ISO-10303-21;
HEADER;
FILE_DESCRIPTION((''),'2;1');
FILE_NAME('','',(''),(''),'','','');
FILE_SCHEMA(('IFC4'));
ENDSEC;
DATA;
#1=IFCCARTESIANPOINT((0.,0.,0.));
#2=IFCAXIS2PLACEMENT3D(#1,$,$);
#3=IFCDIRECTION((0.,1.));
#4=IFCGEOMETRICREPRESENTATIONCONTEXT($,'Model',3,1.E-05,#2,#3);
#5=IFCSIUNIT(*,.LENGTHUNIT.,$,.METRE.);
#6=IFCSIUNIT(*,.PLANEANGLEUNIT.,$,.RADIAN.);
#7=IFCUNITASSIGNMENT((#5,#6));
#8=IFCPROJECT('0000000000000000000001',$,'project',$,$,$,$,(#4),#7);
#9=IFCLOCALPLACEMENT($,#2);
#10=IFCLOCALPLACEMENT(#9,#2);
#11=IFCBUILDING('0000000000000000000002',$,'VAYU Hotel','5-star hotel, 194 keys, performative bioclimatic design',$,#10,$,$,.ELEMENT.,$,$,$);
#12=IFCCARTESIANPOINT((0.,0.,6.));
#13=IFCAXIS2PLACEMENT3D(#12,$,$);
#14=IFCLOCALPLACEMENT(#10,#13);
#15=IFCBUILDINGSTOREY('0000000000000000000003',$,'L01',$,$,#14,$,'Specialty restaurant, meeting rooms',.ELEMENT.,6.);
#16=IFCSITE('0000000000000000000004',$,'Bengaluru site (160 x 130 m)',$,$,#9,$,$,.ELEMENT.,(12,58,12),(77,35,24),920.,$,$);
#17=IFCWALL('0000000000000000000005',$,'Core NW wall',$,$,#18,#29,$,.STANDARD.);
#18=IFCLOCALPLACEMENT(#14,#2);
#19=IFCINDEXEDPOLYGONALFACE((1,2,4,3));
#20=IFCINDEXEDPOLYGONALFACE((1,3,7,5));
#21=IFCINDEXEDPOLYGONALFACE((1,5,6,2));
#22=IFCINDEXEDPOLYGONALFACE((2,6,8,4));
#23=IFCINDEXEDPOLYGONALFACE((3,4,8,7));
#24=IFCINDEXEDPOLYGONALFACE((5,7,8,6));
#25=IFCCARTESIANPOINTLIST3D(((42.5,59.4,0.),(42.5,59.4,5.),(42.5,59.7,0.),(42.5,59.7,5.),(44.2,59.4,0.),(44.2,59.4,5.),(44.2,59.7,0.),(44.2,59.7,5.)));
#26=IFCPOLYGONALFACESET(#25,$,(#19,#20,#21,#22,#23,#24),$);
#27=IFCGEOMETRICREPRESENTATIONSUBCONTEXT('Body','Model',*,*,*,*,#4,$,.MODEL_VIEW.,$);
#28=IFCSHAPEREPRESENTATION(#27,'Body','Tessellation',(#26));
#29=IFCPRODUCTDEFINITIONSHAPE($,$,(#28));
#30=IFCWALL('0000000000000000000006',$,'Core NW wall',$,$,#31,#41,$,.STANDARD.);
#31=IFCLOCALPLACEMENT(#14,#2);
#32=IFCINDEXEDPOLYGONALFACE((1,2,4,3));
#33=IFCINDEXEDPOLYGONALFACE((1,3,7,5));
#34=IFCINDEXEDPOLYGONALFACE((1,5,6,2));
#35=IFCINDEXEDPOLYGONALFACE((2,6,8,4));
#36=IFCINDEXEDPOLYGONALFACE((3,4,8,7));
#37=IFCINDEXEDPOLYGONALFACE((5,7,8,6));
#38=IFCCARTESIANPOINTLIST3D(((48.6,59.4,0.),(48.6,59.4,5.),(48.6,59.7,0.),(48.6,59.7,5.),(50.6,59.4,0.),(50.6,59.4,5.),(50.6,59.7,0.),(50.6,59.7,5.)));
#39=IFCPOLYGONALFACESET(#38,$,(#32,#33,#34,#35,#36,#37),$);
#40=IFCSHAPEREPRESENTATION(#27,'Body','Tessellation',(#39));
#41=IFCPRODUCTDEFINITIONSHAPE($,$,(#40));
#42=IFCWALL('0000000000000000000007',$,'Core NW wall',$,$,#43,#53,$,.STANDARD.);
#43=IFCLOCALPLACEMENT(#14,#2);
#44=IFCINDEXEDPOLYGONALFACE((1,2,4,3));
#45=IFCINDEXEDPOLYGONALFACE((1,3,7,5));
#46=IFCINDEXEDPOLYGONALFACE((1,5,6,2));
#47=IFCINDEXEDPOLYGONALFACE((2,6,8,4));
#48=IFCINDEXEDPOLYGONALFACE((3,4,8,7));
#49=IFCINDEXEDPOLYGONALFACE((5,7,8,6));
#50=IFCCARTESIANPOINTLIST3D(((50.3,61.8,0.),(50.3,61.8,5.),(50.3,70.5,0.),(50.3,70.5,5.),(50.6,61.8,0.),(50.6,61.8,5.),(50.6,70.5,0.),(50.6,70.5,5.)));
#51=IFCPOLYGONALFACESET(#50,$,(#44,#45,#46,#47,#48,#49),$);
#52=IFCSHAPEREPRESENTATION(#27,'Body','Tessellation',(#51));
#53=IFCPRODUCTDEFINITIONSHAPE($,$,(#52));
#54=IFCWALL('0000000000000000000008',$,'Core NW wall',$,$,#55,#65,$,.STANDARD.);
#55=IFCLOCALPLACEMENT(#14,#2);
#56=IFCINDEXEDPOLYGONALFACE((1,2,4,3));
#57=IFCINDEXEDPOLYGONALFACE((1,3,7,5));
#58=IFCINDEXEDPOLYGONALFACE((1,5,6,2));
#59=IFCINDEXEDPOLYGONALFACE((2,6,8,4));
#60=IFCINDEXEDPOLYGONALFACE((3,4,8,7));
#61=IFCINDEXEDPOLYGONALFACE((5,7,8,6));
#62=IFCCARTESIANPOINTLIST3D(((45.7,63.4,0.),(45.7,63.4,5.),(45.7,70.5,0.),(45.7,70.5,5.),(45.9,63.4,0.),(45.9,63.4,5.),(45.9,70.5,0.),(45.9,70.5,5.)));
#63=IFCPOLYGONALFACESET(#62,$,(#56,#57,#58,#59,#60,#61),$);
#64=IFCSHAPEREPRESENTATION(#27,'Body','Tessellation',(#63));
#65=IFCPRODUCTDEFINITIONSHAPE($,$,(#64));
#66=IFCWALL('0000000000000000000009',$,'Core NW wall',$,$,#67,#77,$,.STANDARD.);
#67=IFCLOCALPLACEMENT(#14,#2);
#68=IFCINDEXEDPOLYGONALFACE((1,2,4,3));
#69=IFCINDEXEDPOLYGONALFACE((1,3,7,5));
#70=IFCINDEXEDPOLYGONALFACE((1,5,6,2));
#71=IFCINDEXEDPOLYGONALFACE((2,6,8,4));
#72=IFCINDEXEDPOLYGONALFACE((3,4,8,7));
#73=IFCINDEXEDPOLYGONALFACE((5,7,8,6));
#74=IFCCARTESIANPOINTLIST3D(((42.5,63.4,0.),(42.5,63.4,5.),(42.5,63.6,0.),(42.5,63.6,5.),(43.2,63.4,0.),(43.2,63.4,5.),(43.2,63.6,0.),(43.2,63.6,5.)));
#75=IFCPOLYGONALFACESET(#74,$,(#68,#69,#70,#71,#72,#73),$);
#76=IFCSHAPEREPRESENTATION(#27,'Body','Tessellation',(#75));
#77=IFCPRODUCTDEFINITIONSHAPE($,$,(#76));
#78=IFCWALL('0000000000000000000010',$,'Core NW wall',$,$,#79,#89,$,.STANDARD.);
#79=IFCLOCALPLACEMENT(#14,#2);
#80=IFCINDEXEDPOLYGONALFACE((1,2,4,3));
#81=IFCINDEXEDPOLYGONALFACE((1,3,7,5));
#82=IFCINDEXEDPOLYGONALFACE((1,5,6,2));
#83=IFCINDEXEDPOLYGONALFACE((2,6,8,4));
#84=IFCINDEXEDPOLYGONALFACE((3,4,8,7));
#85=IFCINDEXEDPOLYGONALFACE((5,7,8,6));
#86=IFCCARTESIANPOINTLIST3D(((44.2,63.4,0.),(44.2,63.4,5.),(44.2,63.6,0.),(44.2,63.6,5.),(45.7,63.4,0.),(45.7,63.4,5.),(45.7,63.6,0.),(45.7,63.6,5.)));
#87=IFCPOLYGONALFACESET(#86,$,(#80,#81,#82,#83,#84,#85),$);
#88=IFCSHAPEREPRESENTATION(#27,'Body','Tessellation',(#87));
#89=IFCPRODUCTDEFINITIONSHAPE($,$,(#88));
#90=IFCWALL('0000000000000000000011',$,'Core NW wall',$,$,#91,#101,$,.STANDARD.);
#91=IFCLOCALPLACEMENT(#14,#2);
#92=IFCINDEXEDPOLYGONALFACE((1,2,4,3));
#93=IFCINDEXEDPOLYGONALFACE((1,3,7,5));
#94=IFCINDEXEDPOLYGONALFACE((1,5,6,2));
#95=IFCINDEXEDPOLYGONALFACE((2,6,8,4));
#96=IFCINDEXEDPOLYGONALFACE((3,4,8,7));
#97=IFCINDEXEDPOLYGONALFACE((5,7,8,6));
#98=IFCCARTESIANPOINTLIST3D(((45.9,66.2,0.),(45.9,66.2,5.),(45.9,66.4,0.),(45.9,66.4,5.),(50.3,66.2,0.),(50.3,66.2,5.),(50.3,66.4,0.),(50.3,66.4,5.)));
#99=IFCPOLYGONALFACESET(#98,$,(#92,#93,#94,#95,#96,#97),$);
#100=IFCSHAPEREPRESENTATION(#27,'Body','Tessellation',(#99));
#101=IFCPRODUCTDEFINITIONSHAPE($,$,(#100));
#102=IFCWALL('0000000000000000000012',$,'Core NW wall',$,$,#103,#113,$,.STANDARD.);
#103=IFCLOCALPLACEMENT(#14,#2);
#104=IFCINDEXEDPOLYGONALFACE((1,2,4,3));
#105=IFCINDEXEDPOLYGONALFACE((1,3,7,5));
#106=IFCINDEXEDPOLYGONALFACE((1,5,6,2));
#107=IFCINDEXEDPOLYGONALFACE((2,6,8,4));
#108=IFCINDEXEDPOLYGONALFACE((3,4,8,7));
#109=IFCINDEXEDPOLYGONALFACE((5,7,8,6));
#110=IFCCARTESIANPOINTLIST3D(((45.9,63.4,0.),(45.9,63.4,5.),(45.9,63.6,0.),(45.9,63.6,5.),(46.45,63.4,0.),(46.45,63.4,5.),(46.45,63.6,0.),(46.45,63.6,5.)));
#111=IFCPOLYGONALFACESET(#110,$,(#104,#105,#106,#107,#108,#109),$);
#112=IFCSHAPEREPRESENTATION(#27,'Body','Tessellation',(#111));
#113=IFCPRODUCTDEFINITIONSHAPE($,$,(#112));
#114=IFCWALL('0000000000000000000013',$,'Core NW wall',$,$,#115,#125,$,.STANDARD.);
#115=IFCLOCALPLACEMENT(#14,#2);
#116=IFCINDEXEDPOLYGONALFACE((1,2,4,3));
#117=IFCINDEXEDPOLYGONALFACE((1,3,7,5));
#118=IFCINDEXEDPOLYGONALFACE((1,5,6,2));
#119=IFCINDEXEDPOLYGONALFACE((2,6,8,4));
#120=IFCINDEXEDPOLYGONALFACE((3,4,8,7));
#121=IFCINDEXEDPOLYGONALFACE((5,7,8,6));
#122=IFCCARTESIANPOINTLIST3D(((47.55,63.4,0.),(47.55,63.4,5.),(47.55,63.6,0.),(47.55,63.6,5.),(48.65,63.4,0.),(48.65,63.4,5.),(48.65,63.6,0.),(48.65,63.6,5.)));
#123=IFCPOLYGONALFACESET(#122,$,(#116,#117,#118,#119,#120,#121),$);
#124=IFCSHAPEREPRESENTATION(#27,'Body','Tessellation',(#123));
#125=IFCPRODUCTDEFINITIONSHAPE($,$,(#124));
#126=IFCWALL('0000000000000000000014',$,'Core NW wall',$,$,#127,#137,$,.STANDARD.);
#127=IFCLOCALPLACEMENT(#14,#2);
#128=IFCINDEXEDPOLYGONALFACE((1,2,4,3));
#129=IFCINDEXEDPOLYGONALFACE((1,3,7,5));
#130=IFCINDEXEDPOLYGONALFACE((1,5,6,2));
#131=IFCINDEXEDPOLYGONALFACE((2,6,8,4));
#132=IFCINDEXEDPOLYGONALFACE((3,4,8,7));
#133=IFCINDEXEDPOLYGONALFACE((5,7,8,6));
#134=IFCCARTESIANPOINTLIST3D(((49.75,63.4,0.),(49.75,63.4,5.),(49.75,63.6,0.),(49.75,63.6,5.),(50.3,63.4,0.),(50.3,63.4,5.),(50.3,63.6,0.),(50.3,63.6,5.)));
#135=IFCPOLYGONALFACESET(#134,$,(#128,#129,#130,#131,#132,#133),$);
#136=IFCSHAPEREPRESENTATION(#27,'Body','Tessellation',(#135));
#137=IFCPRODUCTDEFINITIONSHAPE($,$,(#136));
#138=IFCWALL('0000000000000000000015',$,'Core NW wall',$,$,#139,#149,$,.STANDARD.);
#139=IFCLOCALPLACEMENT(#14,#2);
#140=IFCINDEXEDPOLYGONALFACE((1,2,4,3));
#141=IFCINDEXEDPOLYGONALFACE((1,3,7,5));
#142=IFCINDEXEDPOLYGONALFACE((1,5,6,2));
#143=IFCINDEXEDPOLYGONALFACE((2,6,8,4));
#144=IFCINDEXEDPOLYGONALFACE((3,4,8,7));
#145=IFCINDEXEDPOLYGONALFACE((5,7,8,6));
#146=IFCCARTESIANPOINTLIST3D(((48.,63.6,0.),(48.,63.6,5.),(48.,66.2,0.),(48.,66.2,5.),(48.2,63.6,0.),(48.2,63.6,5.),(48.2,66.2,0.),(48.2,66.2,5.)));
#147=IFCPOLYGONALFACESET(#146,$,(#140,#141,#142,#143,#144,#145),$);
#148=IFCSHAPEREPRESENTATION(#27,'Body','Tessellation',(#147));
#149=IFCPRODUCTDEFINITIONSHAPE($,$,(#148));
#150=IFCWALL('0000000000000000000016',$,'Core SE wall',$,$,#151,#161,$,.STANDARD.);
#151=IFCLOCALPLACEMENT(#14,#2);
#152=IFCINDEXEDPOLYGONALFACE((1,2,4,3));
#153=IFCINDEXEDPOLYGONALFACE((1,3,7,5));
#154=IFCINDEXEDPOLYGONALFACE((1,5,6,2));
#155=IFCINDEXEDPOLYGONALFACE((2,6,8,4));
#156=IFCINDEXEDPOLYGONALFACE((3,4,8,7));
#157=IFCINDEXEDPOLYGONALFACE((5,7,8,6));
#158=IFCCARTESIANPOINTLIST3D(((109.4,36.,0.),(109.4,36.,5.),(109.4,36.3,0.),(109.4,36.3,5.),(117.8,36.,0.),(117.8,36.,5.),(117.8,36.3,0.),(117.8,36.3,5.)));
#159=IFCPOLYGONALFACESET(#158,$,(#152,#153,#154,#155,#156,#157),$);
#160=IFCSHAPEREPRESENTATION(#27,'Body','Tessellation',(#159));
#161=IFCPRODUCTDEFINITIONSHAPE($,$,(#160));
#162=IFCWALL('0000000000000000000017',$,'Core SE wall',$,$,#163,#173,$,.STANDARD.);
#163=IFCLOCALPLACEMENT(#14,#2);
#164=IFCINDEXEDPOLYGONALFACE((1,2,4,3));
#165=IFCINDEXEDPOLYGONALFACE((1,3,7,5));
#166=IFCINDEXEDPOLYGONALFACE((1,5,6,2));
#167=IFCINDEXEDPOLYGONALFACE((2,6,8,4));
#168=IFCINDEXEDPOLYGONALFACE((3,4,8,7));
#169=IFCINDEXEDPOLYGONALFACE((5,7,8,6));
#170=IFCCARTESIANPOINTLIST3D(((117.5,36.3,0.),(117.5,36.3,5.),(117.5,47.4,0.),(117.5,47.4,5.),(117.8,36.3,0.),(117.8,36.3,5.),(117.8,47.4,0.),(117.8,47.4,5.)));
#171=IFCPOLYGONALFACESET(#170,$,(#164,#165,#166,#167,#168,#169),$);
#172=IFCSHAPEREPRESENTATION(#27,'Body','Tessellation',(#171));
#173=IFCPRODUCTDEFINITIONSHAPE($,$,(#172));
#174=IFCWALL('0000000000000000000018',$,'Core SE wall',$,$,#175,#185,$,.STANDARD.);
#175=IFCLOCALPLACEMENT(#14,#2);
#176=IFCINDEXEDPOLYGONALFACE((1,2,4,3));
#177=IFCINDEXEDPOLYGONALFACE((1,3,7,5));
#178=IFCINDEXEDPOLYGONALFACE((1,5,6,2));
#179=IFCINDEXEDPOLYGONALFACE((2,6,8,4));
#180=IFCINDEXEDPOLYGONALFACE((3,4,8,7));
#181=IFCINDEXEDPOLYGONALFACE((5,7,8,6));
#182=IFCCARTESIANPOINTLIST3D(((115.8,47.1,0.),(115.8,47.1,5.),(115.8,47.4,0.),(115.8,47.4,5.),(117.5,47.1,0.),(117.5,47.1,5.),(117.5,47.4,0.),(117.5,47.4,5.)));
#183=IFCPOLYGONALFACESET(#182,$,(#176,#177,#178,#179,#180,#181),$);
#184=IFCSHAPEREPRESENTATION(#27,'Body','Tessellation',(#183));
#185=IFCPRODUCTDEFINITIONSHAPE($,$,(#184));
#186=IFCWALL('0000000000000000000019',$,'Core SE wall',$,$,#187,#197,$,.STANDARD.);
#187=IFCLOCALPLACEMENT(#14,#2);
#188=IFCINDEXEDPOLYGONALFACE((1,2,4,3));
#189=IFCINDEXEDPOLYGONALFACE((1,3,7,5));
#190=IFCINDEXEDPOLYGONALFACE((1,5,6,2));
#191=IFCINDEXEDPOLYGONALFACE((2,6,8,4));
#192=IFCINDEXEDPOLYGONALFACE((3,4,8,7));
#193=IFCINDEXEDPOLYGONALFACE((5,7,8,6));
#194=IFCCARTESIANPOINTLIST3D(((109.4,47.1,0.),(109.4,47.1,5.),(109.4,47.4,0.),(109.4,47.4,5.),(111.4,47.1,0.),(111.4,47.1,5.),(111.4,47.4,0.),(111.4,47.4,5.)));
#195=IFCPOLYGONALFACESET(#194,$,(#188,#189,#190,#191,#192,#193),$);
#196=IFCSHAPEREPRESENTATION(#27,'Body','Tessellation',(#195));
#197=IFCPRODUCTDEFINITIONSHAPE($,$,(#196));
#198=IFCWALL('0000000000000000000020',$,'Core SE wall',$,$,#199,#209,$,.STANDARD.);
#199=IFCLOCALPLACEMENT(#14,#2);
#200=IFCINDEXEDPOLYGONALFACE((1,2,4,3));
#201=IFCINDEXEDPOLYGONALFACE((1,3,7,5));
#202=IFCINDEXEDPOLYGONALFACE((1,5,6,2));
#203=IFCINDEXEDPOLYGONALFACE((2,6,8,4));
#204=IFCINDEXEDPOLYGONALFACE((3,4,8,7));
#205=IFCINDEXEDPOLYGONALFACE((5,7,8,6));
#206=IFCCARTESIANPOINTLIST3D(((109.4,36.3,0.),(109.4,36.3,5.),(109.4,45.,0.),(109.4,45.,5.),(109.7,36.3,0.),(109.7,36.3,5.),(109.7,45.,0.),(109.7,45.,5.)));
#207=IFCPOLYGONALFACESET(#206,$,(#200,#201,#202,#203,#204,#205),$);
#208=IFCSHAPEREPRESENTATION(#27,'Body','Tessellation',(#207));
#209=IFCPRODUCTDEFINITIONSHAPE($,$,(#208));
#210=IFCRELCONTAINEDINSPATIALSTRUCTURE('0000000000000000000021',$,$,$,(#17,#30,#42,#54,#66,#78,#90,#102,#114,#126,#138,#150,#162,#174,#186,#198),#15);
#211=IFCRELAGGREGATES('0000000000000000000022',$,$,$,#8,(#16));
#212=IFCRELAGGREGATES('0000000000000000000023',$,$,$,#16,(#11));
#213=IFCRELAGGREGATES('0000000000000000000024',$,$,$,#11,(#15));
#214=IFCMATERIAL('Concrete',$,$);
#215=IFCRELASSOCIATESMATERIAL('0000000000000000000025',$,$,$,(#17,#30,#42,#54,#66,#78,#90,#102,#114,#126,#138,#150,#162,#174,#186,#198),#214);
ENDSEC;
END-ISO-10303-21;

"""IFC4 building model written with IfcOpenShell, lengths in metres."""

from ifc_helpers import new_model, si_unit, direction, frame, origin, place, context, subcontext, project, spatial, polyline, outline, extrude, material, element, save


model = new_model("IFC4")

# Units and contexts
model_context = context("Model", 3, precision=1e-05, world=origin(), true_north=direction((0.0, 1.0)))
body_context = subcontext(model_context, "Body", "Model", "MODEL_VIEW")
ifc_project = project(units=[si_unit("LENGTHUNIT", "METRE"), si_unit("PLANEANGLEUNIT", "RADIAN")], contexts=[model_context])

# Site, building, storey
site_placement = place(None, origin())
site = spatial("IfcSite", under=ifc_project, at=site_placement, Name="Bengaluru site (160 x 130 m)", CompositionType="ELEMENT", RefLatitude=(12, 58, 12), RefLongitude=(77, 35, 24), RefElevation=920.0)
building_placement = place(site_placement, origin())
building = spatial("IfcBuilding", under=site, at=building_placement, Name="VAYU Hotel", Description="5-star hotel, 194 keys, performative bioclimatic design", CompositionType="ELEMENT")
storey_placement = place(building_placement, frame((0.0, 0.0, 6.0)))
storey = spatial("IfcBuildingStorey", under=building, at=storey_placement, Name="L01", LongName="Specialty restaurant, meeting rooms", CompositionType="ELEMENT", Elevation=6.0)

# Walls
ifc_material = material(Name="Concrete")
wall_1_placement = place(storey_placement, origin())
element("IfcWall", 1, at=wall_1_placement, inside=storey, material=ifc_material, Name="Core NW wall", PredefinedType="STANDARD", context=body_context, shape_type="SweptSolid", body=[
    extrude(outline(polyline([(42.5, 59.7), (44.2, 59.7), (44.2, 59.4), (42.5, 59.4), (42.5, 59.7)])), origin(), (0.0, 0.0, 1.0), 5.0),
])
wall_2_placement = place(storey_placement, origin())
element("IfcWall", 2, at=wall_2_placement, inside=storey, material=ifc_material, Name="Core NW wall", PredefinedType="STANDARD", context=body_context, shape_type="SweptSolid", body=[
    extrude(outline(polyline([(48.6, 59.7), (50.6, 59.7), (50.6, 59.4), (48.6, 59.4), (48.6, 59.7)])), origin(), (0.0, 0.0, 1.0), 5.0),
])
wall_3_placement = place(storey_placement, origin())
element("IfcWall", 3, at=wall_3_placement, inside=storey, material=ifc_material, Name="Core NW wall", PredefinedType="STANDARD", context=body_context, shape_type="SweptSolid", body=[
    extrude(outline(polyline([(50.3, 61.8), (50.3, 70.5), (50.6, 70.5), (50.6, 61.8), (50.3, 61.8)])), origin(), (0.0, 0.0, 1.0), 5.0),
])
wall_4_placement = place(storey_placement, origin())
element("IfcWall", 4, at=wall_4_placement, inside=storey, material=ifc_material, Name="Core NW wall", PredefinedType="STANDARD", context=body_context, shape_type="SweptSolid", body=[
    extrude(outline(polyline([(45.7, 63.4), (45.7, 70.5), (45.9, 70.5), (45.9, 63.4), (45.7, 63.4)])), origin(), (0.0, 0.0, 1.0), 5.0),
])
wall_5_placement = place(storey_placement, origin())
element("IfcWall", 5, at=wall_5_placement, inside=storey, material=ifc_material, Name="Core NW wall", PredefinedType="STANDARD", context=body_context, shape_type="SweptSolid", body=[
    extrude(outline(polyline([(42.5, 63.6), (43.2, 63.6), (43.2, 63.4), (42.5, 63.4), (42.5, 63.6)])), origin(), (0.0, 0.0, 1.0), 5.0),
])
wall_6_placement = place(storey_placement, origin())
element("IfcWall", 6, at=wall_6_placement, inside=storey, material=ifc_material, Name="Core NW wall", PredefinedType="STANDARD", context=body_context, shape_type="SweptSolid", body=[
    extrude(outline(polyline([(44.2, 63.6), (45.7, 63.6), (45.7, 63.4), (44.2, 63.4), (44.2, 63.6)])), origin(), (0.0, 0.0, 1.0), 5.0),
])
wall_7_placement = place(storey_placement, origin())
element("IfcWall", 7, at=wall_7_placement, inside=storey, material=ifc_material, Name="Core NW wall", PredefinedType="STANDARD", context=body_context, shape_type="SweptSolid", body=[
    extrude(outline(polyline([(45.9, 66.4), (50.3, 66.4), (50.3, 66.2), (45.9, 66.2), (45.9, 66.4)])), origin(), (0.0, 0.0, 1.0), 5.0),
])
wall_8_placement = place(storey_placement, origin())
element("IfcWall", 8, at=wall_8_placement, inside=storey, material=ifc_material, Name="Core NW wall", PredefinedType="STANDARD", context=body_context, shape_type="SweptSolid", body=[
    extrude(outline(polyline([(45.9, 63.6), (46.45, 63.6), (46.45, 63.4), (45.9, 63.4), (45.9, 63.6)])), origin(), (0.0, 0.0, 1.0), 5.0),
])
wall_9_placement = place(storey_placement, origin())
element("IfcWall", 9, at=wall_9_placement, inside=storey, material=ifc_material, Name="Core NW wall", PredefinedType="STANDARD", context=body_context, shape_type="SweptSolid", body=[
    extrude(outline(polyline([(47.55, 63.6), (48.65, 63.6), (48.65, 63.4), (47.55, 63.4), (47.55, 63.6)])), origin(), (0.0, 0.0, 1.0), 5.0),
])
wall_10_placement = place(storey_placement, origin())
element("IfcWall", 10, at=wall_10_placement, inside=storey, material=ifc_material, Name="Core NW wall", PredefinedType="STANDARD", context=body_context, shape_type="SweptSolid", body=[
    extrude(outline(polyline([(49.75, 63.6), (50.3, 63.6), (50.3, 63.4), (49.75, 63.4), (49.75, 63.6)])), origin(), (0.0, 0.0, 1.0), 5.0),
])
wall_11_placement = place(storey_placement, origin())
element("IfcWall", 11, at=wall_11_placement, inside=storey, material=ifc_material, Name="Core NW wall", PredefinedType="STANDARD", context=body_context, shape_type="SweptSolid", body=[
    extrude(outline(polyline([(48.0, 63.6), (48.0, 66.2), (48.2, 66.2), (48.2, 63.6), (48.0, 63.6)])), origin(), (0.0, 0.0, 1.0), 5.0),
])
wall_12_placement = place(storey_placement, origin())
element("IfcWall", 12, at=wall_12_placement, inside=storey, material=ifc_material, Name="Core SE wall", PredefinedType="STANDARD", context=body_context, shape_type="SweptSolid", body=[
    extrude(outline(polyline([(109.4, 36.3), (117.8, 36.3), (117.8, 36.0), (109.4, 36.0), (109.4, 36.3)])), origin(), (0.0, 0.0, 1.0), 5.0),
])
wall_13_placement = place(storey_placement, origin())
element("IfcWall", 13, at=wall_13_placement, inside=storey, material=ifc_material, Name="Core SE wall", PredefinedType="STANDARD", context=body_context, shape_type="SweptSolid", body=[
    extrude(outline(polyline([(117.5, 36.3), (117.5, 47.4), (117.8, 47.4), (117.8, 36.3), (117.5, 36.3)])), origin(), (0.0, 0.0, 1.0), 5.0),
])
wall_14_placement = place(storey_placement, origin())
element("IfcWall", 14, at=wall_14_placement, inside=storey, material=ifc_material, Name="Core SE wall", PredefinedType="STANDARD", context=body_context, shape_type="SweptSolid", body=[
    extrude(outline(polyline([(115.8, 47.4), (117.5, 47.4), (117.5, 47.1), (115.8, 47.1), (115.8, 47.4)])), origin(), (0.0, 0.0, 1.0), 5.0),
])
wall_15_placement = place(storey_placement, origin())
element("IfcWall", 15, at=wall_15_placement, inside=storey, material=ifc_material, Name="Core SE wall", PredefinedType="STANDARD", context=body_context, shape_type="SweptSolid", body=[
    extrude(outline(polyline([(109.4, 47.4), (111.4, 47.4), (111.4, 47.1), (109.4, 47.1), (109.4, 47.4)])), origin(), (0.0, 0.0, 1.0), 5.0),
])
wall_16_placement = place(storey_placement, origin())
element("IfcWall", 16, at=wall_16_placement, inside=storey, material=ifc_material, Name="Core SE wall", PredefinedType="STANDARD", context=body_context, shape_type="SweptSolid", body=[
    extrude(outline(polyline([(109.4, 36.3), (109.4, 45.0), (109.7, 45.0), (109.7, 36.3), (109.4, 36.3)])), origin(), (0.0, 0.0, 1.0), 5.0),
])

save(model, "model.ifc")
